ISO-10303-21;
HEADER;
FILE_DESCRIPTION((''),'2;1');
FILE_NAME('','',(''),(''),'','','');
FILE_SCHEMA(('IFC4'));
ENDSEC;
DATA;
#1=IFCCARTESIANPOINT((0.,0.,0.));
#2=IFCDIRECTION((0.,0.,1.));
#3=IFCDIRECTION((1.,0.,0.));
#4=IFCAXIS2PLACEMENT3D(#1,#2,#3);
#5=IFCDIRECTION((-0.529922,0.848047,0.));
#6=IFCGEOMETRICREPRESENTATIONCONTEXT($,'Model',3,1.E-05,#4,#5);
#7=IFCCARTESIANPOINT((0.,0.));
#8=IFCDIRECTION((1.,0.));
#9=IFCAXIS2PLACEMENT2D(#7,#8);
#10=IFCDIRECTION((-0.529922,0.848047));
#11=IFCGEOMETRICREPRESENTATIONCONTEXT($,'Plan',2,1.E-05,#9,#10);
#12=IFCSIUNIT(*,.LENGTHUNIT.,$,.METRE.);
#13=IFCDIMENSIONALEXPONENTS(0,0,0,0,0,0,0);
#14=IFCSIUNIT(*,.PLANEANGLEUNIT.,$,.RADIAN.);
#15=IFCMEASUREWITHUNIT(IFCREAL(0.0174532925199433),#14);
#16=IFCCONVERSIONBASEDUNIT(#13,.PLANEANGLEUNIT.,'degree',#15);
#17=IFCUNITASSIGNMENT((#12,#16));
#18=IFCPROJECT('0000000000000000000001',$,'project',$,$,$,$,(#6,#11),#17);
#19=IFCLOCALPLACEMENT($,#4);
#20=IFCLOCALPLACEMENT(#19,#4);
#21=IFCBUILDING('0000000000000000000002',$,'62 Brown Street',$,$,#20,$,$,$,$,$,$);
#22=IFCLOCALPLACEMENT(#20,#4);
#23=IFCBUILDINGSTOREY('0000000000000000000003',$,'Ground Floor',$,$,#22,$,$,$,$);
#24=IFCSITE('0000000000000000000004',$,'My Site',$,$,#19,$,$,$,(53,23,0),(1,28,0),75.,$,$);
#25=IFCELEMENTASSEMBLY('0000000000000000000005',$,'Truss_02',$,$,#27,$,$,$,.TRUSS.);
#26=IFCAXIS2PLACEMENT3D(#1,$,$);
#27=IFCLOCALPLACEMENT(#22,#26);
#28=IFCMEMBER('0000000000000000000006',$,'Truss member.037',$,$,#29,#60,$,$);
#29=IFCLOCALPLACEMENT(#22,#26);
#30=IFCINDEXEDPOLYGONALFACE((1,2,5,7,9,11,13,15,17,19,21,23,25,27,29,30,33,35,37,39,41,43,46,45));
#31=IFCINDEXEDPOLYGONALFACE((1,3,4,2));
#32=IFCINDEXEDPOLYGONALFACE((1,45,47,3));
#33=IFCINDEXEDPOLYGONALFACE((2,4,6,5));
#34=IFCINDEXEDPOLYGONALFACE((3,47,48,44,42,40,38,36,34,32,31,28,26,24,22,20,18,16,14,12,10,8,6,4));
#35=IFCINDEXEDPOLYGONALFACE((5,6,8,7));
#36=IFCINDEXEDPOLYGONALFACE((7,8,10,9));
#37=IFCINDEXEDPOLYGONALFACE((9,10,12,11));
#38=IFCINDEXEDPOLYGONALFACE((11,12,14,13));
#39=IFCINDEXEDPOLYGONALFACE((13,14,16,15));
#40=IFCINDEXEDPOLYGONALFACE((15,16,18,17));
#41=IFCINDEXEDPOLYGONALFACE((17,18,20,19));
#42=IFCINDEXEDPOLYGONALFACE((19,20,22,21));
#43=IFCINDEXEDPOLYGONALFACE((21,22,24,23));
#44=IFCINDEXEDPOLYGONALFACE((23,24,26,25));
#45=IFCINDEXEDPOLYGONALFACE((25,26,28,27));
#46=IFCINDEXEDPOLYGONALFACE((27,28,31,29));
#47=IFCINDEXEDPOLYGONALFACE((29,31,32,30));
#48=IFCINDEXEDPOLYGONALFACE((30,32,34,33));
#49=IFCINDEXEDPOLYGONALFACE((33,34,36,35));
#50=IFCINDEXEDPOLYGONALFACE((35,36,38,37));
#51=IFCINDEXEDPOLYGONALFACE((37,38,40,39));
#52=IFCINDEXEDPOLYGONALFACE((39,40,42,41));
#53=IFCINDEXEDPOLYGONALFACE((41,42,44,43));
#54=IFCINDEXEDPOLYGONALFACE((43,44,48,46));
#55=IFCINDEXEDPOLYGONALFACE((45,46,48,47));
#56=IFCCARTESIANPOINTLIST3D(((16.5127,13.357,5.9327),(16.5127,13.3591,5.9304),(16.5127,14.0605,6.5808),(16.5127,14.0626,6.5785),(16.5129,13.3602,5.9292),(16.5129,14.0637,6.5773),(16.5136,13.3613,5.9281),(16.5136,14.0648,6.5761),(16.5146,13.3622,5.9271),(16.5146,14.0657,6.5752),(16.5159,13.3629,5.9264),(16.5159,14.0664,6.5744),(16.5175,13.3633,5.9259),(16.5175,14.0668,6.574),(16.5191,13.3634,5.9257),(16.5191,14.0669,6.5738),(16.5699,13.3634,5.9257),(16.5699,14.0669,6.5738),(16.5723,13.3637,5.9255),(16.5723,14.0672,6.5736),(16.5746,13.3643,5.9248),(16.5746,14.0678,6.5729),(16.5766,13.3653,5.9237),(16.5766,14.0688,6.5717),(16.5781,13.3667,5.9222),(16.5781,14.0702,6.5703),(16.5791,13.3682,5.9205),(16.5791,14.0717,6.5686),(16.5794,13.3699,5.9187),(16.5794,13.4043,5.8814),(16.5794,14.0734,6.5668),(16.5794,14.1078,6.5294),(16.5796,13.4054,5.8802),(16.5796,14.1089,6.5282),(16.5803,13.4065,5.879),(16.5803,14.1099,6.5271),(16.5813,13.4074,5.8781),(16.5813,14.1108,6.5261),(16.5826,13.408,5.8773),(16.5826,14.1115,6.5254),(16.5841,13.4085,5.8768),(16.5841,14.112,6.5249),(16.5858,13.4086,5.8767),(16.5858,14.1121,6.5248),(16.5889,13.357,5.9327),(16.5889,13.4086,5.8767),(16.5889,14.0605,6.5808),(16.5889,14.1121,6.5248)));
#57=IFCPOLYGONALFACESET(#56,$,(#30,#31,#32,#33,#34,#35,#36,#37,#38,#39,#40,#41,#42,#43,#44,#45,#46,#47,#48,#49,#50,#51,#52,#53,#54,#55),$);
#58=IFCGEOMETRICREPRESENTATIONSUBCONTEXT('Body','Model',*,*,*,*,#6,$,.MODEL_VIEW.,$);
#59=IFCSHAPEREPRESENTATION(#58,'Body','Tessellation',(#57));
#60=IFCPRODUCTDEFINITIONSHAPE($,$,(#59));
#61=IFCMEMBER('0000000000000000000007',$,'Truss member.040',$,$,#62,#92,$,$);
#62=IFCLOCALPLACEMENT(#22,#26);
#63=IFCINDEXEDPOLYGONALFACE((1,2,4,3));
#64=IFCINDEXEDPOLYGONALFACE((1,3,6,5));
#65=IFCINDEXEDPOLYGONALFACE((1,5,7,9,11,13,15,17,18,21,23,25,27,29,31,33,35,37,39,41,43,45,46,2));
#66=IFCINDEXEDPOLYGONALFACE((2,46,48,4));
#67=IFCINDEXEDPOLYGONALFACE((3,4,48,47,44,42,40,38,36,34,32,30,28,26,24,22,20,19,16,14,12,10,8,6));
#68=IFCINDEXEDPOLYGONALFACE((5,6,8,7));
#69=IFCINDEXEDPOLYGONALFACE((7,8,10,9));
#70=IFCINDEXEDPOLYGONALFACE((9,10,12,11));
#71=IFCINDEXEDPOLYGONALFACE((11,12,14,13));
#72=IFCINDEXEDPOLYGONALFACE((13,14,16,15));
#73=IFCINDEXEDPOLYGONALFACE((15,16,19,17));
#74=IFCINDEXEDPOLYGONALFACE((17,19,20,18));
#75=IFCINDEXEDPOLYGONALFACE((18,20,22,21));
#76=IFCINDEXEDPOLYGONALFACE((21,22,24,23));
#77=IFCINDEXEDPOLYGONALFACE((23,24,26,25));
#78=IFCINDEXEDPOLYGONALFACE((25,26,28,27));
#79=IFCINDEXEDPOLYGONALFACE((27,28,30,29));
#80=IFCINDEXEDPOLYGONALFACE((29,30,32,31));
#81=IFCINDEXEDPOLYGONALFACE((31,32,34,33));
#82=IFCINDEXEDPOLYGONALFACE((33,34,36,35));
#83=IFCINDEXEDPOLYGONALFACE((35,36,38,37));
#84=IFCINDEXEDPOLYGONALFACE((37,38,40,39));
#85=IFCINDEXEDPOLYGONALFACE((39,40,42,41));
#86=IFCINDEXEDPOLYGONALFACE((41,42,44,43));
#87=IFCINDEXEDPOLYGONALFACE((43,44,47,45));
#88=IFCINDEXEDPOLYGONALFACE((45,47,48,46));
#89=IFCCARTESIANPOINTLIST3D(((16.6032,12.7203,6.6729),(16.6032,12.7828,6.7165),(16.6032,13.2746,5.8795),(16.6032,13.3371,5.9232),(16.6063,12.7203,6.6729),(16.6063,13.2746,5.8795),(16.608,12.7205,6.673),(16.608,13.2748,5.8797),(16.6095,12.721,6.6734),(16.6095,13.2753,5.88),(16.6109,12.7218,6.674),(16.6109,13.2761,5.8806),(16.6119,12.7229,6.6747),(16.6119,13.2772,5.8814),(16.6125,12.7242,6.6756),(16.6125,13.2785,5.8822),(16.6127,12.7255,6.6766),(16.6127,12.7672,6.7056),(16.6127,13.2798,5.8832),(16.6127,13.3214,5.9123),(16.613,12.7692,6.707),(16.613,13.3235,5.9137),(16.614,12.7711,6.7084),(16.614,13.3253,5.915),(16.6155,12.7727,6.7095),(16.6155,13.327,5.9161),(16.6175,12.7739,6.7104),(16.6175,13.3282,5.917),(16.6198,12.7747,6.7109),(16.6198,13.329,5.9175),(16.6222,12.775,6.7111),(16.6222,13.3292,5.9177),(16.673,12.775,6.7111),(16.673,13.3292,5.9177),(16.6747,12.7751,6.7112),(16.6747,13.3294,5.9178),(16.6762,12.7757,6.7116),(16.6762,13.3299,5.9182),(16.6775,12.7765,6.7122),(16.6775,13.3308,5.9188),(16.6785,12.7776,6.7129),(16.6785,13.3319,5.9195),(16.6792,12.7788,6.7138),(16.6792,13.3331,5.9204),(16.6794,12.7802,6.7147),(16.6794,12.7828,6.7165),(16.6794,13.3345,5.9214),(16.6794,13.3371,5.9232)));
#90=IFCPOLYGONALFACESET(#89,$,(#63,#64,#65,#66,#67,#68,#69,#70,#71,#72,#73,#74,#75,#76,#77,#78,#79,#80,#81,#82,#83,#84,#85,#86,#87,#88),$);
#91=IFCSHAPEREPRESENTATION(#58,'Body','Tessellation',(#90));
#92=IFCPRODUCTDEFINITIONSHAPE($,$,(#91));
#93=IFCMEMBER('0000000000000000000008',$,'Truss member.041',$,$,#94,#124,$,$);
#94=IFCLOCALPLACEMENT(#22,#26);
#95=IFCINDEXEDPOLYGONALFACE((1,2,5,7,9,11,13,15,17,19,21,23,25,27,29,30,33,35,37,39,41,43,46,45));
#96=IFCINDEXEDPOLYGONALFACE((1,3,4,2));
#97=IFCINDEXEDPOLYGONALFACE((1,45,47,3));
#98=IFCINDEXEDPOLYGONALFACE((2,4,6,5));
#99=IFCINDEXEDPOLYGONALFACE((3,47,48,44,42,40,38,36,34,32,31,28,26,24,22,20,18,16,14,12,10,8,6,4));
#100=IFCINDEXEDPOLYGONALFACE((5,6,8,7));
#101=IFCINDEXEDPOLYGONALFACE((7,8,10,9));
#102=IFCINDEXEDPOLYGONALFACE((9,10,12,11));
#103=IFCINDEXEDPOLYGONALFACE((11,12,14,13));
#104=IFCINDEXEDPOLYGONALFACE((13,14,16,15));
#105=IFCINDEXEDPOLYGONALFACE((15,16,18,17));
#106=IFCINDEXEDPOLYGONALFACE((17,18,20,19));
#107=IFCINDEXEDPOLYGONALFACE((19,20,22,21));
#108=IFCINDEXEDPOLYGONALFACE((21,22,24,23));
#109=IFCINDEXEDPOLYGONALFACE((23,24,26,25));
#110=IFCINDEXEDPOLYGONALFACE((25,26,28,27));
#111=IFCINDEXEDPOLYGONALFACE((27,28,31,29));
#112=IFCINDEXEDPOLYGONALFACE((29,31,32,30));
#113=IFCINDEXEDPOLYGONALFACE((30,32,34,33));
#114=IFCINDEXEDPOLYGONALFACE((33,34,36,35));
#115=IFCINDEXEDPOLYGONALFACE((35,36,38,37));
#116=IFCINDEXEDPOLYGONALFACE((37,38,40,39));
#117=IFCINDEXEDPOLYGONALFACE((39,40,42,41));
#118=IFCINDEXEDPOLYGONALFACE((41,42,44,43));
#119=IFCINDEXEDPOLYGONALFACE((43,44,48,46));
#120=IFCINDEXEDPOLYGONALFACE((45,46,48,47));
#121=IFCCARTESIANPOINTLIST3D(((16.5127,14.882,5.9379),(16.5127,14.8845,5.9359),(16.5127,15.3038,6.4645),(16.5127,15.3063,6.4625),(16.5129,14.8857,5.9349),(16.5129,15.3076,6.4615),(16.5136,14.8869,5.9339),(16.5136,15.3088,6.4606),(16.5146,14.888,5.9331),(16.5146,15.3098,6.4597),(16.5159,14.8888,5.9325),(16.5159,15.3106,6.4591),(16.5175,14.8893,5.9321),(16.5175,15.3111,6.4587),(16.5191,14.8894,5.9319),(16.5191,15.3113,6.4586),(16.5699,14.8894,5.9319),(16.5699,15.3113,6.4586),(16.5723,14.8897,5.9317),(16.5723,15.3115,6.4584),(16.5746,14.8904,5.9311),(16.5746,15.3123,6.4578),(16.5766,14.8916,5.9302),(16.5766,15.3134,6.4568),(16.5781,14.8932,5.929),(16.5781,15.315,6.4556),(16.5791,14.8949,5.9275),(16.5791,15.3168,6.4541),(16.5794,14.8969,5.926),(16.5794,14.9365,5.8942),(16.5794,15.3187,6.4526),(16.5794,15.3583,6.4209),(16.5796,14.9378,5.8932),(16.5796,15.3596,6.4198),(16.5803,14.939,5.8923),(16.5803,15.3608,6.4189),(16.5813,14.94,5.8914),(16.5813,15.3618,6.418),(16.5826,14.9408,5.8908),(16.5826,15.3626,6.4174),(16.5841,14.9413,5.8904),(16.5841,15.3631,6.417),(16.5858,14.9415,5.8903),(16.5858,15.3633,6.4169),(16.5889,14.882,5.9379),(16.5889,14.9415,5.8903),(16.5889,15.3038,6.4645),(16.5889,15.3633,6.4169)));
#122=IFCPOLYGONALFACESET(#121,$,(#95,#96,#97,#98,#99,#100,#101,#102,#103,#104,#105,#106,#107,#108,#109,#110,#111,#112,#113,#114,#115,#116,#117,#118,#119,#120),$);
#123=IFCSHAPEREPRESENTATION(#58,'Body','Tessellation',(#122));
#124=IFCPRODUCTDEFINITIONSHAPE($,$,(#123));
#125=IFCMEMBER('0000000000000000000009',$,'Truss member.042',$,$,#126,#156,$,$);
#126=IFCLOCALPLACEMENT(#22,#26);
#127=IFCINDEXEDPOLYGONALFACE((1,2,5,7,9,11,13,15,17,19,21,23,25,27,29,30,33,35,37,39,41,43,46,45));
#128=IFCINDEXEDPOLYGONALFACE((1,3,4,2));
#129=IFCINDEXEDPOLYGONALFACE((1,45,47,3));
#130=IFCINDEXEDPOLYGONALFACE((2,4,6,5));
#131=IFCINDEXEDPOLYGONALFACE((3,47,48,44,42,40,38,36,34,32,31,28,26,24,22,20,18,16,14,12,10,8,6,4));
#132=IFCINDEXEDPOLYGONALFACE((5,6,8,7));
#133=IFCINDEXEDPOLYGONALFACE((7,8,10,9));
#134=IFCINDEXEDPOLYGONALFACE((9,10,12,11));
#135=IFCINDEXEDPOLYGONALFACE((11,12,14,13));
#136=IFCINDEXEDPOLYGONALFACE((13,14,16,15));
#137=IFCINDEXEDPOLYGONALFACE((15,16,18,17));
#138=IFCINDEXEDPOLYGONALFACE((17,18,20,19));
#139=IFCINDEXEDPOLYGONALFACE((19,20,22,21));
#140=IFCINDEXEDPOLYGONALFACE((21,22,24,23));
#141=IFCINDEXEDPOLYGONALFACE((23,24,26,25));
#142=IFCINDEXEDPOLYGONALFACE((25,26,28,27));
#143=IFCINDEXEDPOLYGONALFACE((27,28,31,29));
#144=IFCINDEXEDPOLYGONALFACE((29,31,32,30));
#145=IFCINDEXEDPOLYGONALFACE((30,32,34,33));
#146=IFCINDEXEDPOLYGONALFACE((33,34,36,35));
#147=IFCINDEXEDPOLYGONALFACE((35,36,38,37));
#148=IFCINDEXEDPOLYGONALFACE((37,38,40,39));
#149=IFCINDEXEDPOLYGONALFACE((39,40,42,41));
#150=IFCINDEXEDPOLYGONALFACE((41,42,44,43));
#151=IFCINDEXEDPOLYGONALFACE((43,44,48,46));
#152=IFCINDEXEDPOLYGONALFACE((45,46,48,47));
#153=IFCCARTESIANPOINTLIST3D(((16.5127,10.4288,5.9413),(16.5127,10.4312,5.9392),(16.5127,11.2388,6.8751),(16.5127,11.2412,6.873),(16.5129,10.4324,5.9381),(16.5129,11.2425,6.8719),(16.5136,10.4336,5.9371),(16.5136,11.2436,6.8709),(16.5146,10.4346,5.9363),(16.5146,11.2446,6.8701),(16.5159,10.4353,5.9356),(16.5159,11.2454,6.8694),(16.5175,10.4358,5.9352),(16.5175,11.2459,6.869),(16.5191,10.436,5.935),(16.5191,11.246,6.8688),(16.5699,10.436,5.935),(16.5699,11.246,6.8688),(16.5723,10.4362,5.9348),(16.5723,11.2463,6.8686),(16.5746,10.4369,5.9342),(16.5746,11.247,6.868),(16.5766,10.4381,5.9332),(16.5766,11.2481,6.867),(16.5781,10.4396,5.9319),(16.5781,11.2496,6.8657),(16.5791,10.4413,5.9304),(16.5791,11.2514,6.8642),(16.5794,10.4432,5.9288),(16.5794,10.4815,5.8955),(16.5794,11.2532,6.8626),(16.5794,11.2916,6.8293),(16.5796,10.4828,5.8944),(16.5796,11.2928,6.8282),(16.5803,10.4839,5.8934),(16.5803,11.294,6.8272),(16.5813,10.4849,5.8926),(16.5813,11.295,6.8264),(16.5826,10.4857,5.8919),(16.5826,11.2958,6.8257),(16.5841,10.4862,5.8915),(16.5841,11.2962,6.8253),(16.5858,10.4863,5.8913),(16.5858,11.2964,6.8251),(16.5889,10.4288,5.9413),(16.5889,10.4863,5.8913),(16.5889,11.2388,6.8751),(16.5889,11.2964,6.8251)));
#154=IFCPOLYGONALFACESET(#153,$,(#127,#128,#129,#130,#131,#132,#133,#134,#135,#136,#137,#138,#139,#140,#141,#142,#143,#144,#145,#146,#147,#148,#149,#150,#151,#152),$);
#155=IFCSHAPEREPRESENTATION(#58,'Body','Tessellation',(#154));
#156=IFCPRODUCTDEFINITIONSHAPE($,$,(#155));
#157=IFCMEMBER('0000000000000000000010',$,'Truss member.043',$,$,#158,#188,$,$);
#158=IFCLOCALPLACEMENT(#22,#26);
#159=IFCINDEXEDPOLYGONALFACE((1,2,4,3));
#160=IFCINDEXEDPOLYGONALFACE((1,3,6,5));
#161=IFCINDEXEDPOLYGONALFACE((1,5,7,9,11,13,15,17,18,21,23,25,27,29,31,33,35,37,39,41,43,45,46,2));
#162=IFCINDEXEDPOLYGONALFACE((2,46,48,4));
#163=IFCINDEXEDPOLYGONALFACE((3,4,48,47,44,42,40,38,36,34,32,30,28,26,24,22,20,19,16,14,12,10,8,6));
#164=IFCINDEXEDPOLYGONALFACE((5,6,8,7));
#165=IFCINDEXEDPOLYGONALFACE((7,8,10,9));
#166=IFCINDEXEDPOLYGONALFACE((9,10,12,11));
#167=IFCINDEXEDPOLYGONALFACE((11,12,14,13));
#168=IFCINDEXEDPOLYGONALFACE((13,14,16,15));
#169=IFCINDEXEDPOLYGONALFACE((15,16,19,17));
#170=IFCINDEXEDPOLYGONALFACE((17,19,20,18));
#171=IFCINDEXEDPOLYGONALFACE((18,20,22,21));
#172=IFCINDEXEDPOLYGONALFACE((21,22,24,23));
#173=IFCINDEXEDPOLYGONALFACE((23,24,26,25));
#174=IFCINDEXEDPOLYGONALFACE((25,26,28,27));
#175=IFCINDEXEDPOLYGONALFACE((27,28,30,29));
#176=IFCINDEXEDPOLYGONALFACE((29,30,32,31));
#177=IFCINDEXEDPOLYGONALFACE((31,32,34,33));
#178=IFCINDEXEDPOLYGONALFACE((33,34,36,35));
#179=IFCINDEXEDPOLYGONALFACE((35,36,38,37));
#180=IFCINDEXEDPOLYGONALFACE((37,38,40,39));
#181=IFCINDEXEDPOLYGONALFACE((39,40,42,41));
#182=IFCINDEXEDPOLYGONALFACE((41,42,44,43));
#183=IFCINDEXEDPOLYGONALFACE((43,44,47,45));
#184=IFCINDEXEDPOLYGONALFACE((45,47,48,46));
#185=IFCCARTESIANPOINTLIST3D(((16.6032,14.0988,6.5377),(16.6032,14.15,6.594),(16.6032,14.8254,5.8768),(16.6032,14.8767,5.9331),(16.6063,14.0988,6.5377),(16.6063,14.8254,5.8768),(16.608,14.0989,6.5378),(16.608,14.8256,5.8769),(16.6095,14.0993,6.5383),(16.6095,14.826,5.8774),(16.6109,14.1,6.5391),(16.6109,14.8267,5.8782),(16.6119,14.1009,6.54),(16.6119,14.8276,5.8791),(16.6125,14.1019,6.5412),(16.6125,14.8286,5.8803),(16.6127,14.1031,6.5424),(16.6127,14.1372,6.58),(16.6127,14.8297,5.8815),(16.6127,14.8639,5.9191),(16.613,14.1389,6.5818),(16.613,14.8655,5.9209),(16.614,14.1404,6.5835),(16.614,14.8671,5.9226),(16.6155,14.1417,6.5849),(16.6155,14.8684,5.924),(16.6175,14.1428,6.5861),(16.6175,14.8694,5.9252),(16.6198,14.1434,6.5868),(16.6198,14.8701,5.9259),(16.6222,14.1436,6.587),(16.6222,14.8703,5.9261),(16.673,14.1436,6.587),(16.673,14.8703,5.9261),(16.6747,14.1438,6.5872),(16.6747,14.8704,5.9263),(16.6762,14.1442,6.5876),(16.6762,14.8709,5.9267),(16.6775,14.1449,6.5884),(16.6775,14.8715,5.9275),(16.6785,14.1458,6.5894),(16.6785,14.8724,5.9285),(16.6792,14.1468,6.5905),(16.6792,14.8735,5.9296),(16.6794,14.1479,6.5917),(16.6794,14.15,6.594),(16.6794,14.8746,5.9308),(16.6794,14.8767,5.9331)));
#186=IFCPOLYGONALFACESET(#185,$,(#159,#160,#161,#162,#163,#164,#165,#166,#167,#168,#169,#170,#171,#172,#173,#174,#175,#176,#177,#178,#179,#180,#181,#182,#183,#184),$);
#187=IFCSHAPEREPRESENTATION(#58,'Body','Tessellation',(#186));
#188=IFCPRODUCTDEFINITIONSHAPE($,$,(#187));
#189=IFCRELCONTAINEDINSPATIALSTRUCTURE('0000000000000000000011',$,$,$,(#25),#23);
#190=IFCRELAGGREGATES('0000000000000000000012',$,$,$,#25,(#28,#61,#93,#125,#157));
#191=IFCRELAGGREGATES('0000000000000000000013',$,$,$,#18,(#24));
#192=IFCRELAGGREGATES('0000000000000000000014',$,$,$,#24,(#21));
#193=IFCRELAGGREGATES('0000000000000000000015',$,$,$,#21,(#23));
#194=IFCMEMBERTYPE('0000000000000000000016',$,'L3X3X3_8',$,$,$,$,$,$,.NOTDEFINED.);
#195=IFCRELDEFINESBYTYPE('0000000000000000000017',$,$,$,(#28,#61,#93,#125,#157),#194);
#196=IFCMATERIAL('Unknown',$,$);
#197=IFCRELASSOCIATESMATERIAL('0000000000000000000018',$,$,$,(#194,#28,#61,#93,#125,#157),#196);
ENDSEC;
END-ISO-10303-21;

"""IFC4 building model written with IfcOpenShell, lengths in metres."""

from ifc_helpers import new_model, entity, si_unit, converted_unit, direction, frame, origin_with_axes, origin_2d_with_axis, place, context, subcontext, project, spatial, l_section, extrude, material, material_profile, profile_set, profile_usage, type_object, element, aggregate, save


model = new_model("IFC4")

# Units and contexts
model_context = context("Model", 3, precision=1e-05, world=origin_with_axes(), true_north=direction((-0.529922, 0.848047, 0.0)))
plan_context = context("Plan", 2, precision=1e-05, world=origin_2d_with_axis(), true_north=direction((-0.529922, 0.848047)))
body_context = subcontext(model_context, "Body", "Model", "MODEL_VIEW")
ifc_project = project(units=[si_unit("LENGTHUNIT", "METRE"), converted_unit("PLANEANGLEUNIT", "degree", entity("IfcReal", 0.0174532925199433), si_unit("PLANEANGLEUNIT", "RADIAN"), dimensions=[0, 0, 0, 0, 0, 0, 0])], contexts=[model_context, plan_context])

# Site, building, storey
site_placement = place(None, origin_with_axes())
site = spatial("IfcSite", under=ifc_project, at=site_placement, Name="My Site", RefLatitude=(53, 23, 0), RefLongitude=(1, 28, 0), RefElevation=75.0)
building_placement = place(site_placement, origin_with_axes())
building = spatial("IfcBuilding", under=site, at=building_placement, Name="62 Brown Street")
storey_placement = place(building_placement, origin_with_axes())
storey = spatial("IfcBuildingStorey", under=building, at=storey_placement, Name="Ground Floor")

# Element assembly, members
ifc_material_1 = material(Name="Unknown")
ifc_material_profile_1 = material_profile(ifc_material_1, l_section(Depth=0.0762, Width=0.0762, Thickness=0.0095, FilletRadius=0.0095, EdgeRadius=0.0064))
ifc_profile_set_1 = profile_set([ifc_material_profile_1])
member_type_1 = type_object("IfcMemberType", Name="L3X3X3_8", PredefinedType="NOTDEFINED", material=ifc_profile_set_1)
assembly_1_placement = place(storey_placement, frame((16.6032, 10.4288, 6.9738), z_axis=(0.0, 0.0, 1.0), x_axis=(1.0, 0.0, 0.0)))
assembly_1 = element("IfcElementAssembly", 1, at=assembly_1_placement, inside=storey, Name="Truss_02", PredefinedType="TRUSS")
ifc_profile_usage_1 = profile_usage(ifc_profile_set_1, cardinal=5)
member_1_placement = place(assembly_1_placement, frame((-0.0524, 3.6575, -0.421), z_axis=(0.000001, -0.735484, -0.677542), x_axis=(-1.0, -0.000001, 0.0)))
member_1 = element("IfcMember", 2, at=member_1_placement, type_object=member_type_1, material=ifc_profile_usage_1, Name="Truss member.037", context=body_context, shape_type="SweptSolid", body=[
    extrude(l_section(Depth=0.0762, Width=0.0762, Thickness=0.0095, FilletRadius=0.0095, EdgeRadius=0.0064), origin_with_axes(), (0.0, 0.0, 1.0), 0.9565),
])
ifc_profile_usage_2 = profile_usage(ifc_profile_set_1, cardinal=5)
member_2_placement = place(assembly_1_placement, frame((0.0381, 2.3228, -0.279), z_axis=(-0.000001, 0.572709, -0.819759), x_axis=(1.0, 0.0, 0.0)))
member_2 = element("IfcMember", 3, at=member_2_placement, type_object=member_type_1, material=ifc_profile_usage_2, Name="Truss member.040", context=body_context, shape_type="SweptSolid", body=[
    extrude(l_section(Depth=0.0762, Width=0.0762, Thickness=0.0095, FilletRadius=0.0095, EdgeRadius=0.0064), origin_with_axes(), (0.0, 0.0, 1.0), 0.9678),
])
ifc_profile_usage_3 = profile_usage(ifc_profile_set_1, cardinal=5)
member_3_placement = place(assembly_1_placement, frame((-0.0524, 4.9048, -0.5331), z_axis=(0.000001, -0.625169, -0.780489), x_axis=(-1.0, -0.000001, 0.0)))
member_3 = element("IfcMember", 4, at=member_3_placement, type_object=member_type_1, material=ifc_profile_usage_3, Name="Truss member.041", context=body_context, shape_type="SweptSolid", body=[
    extrude(l_section(Depth=0.0762, Width=0.0762, Thickness=0.0095, FilletRadius=0.0095, EdgeRadius=0.0064), origin_with_axes(), (0.0, 0.0, 1.0), 0.6747),
])
ifc_profile_usage_4 = profile_usage(ifc_profile_set_1, cardinal=5)
member_4_placement = place(assembly_1_placement, frame((-0.0524, 0.8388, -0.1236), z_axis=(0.000001, -0.655276, -0.755389), x_axis=(-1.0, -0.000001, 0.0)))
member_4 = element("IfcMember", 5, at=member_4_placement, type_object=member_type_1, material=ifc_profile_usage_4, Name="Truss member.042", context=body_context, shape_type="SweptSolid", body=[
    extrude(l_section(Depth=0.0762, Width=0.0762, Thickness=0.0095, FilletRadius=0.0095, EdgeRadius=0.0064), origin_with_axes(), (0.0, 0.0, 1.0), 1.2362),
])
ifc_profile_usage_5 = profile_usage(ifc_profile_set_1, cardinal=5)
member_5_placement = place(assembly_1_placement, frame((0.0381, 3.6956, -0.4079), z_axis=(-0.000001, 0.739785, -0.672843), x_axis=(1.0, 0.000001, 0.0)))
member_5 = element("IfcMember", 6, at=member_5_placement, type_object=member_type_1, material=ifc_profile_usage_5, Name="Truss member.043", context=body_context, shape_type="SweptSolid", body=[
    extrude(l_section(Depth=0.0762, Width=0.0762, Thickness=0.0095, FilletRadius=0.0095, EdgeRadius=0.0064), origin_with_axes(), (0.0, 0.0, 1.0), 0.9823),
])

aggregate(assembly_1, [member_1, member_2, member_3, member_4, member_5])

save(model, "model.ifc")
